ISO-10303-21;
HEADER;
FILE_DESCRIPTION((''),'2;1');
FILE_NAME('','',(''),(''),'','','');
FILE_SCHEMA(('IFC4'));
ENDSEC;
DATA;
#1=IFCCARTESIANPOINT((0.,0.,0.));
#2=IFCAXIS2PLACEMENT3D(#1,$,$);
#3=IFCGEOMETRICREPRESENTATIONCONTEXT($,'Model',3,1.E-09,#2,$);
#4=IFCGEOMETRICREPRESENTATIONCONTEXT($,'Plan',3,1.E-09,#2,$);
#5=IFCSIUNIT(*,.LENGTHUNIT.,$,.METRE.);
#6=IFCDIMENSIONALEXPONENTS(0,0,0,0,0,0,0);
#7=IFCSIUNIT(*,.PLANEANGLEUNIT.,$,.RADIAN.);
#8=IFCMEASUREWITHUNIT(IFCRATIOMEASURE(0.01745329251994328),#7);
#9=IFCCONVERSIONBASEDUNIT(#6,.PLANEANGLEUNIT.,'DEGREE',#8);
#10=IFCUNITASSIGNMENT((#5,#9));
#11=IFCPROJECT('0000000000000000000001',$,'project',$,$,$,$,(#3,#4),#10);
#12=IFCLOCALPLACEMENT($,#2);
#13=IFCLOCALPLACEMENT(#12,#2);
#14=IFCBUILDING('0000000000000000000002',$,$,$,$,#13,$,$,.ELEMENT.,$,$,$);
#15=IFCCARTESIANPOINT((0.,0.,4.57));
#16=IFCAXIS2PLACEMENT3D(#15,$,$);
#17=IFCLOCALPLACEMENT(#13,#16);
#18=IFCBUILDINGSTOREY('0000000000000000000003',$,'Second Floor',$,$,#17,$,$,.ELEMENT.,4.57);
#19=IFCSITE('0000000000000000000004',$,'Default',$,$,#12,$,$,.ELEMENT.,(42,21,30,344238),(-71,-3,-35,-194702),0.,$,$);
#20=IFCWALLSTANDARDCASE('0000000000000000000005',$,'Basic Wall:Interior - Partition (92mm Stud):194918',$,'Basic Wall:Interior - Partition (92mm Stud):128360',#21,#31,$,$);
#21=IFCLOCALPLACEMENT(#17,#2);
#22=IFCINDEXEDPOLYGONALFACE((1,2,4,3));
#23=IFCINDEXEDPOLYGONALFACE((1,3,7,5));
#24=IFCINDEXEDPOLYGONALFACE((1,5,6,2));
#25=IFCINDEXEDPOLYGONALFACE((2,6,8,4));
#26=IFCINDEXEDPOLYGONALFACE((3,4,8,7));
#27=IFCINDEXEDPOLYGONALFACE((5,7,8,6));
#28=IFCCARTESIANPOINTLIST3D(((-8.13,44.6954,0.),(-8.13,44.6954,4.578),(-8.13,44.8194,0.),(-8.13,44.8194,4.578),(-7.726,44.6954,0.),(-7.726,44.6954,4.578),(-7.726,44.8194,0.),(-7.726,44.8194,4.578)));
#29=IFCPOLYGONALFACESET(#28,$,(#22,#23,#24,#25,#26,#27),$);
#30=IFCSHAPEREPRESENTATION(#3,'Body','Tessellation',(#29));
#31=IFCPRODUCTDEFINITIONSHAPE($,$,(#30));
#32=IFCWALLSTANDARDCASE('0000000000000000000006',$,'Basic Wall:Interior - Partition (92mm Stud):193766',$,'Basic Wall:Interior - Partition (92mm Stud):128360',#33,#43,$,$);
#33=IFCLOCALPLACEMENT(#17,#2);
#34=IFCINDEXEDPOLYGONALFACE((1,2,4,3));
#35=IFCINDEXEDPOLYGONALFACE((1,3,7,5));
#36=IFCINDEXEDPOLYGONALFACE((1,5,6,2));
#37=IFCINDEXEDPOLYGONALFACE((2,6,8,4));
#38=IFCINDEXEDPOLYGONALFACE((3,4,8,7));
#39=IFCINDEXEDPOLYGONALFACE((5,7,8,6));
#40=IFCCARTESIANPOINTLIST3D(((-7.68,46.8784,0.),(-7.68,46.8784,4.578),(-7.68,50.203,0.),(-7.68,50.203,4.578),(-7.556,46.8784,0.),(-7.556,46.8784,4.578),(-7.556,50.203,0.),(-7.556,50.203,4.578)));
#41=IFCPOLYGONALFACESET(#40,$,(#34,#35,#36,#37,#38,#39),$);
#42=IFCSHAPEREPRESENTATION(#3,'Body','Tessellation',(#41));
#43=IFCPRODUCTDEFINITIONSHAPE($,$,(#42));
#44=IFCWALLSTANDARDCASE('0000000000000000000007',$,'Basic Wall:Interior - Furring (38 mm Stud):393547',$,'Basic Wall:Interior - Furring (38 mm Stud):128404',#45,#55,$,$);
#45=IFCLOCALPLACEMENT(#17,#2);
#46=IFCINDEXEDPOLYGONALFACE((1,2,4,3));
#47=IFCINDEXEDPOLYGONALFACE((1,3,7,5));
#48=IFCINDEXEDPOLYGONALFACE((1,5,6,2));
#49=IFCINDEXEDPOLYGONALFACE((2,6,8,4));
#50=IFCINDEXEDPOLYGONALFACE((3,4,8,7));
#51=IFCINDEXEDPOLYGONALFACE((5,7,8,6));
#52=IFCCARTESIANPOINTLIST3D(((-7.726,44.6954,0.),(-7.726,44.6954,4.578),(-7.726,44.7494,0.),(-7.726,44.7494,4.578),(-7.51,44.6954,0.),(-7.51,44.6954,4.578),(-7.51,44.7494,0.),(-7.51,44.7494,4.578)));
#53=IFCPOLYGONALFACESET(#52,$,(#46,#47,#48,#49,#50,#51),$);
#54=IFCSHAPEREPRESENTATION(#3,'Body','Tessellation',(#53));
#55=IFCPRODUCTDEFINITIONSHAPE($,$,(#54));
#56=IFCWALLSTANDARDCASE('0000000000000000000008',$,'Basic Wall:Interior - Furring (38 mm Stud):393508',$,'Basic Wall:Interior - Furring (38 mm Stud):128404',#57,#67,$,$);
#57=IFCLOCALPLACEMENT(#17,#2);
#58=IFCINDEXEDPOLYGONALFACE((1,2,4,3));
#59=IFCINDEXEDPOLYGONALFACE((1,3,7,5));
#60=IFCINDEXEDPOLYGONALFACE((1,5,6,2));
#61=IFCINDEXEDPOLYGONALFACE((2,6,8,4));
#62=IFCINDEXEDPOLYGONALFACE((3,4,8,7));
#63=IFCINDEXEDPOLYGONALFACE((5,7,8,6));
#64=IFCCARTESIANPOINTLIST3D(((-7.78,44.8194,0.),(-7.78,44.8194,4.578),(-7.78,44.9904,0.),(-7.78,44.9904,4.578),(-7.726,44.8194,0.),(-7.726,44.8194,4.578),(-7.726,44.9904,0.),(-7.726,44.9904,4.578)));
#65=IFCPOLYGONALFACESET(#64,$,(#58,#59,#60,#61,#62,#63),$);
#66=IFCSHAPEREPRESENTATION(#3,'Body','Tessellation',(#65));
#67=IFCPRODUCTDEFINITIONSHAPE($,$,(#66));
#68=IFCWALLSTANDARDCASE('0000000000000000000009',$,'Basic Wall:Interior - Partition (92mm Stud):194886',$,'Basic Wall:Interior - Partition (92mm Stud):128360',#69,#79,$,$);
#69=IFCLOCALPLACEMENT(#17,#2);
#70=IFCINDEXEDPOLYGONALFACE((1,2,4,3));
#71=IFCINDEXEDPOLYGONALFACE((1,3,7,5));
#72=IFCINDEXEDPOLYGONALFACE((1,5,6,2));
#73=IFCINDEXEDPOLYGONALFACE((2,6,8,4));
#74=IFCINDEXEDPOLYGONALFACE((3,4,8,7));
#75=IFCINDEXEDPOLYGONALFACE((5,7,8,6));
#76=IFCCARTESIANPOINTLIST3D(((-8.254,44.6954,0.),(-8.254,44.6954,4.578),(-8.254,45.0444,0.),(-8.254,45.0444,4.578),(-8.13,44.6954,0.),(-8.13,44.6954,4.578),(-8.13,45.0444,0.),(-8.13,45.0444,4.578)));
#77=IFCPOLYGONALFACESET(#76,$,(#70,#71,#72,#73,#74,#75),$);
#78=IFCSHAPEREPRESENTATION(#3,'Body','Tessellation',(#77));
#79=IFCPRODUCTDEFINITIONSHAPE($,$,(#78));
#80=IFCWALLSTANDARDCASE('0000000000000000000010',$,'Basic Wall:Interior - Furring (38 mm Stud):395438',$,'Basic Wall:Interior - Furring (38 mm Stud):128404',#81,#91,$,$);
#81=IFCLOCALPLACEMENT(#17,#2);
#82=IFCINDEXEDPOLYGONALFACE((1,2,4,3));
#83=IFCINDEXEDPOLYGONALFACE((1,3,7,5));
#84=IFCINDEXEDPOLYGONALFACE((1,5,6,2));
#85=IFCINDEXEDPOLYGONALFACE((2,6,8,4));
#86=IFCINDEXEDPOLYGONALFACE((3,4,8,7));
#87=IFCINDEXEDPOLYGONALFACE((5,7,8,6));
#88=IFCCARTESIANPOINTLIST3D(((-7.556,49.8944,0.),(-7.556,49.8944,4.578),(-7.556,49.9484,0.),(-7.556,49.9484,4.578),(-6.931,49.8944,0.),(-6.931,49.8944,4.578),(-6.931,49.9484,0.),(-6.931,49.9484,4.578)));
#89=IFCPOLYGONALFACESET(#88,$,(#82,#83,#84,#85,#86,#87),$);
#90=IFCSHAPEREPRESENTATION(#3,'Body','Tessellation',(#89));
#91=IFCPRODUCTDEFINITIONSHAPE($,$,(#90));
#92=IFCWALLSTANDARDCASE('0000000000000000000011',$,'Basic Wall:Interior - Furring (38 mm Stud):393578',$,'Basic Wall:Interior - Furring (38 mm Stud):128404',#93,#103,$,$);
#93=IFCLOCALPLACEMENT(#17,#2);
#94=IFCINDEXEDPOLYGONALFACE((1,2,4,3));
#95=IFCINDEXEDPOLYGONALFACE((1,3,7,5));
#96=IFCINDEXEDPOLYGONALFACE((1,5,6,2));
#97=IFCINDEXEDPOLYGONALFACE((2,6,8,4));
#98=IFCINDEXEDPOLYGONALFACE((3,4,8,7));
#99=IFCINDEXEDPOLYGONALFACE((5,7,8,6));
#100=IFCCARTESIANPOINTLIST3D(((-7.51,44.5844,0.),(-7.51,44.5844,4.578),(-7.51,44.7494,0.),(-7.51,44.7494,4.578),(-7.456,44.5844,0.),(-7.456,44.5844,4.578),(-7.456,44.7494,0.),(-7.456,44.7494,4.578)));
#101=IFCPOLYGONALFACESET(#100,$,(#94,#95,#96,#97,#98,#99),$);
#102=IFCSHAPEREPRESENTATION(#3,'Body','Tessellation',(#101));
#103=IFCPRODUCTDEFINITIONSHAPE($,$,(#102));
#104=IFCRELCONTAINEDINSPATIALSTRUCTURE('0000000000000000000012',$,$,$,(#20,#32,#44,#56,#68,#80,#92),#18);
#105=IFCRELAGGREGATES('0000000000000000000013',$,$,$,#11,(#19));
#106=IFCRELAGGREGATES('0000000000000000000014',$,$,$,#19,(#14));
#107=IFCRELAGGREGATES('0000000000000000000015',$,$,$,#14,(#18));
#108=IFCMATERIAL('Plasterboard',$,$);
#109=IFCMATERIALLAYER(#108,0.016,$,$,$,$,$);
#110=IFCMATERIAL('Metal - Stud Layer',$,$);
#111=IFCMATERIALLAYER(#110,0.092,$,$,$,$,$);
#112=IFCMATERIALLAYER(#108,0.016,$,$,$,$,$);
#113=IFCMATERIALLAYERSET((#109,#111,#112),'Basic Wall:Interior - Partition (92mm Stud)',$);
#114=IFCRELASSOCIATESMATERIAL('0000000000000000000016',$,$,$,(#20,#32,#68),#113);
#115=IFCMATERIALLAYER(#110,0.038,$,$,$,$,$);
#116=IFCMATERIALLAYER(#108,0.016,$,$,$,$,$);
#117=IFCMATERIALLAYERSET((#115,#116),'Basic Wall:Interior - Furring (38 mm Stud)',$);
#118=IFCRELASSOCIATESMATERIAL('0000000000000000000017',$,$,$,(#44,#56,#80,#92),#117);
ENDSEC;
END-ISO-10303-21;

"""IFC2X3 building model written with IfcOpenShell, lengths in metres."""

from ifc_helpers import new_model, entity, si_unit, converted_unit, frame, frame_2d, origin, place, context, project, spatial, rectangle, extrude, material, layer, layer_set, layer_usage, element, save


model = new_model("IFC2X3")

# Units and contexts
model_context = context("Model", 3, precision=1e-09, world=origin())
plan_context = context("Plan", 3, precision=1e-09, world=origin())
ifc_project = project(units=[si_unit("LENGTHUNIT", "METRE"), converted_unit("PLANEANGLEUNIT", "DEGREE", entity("IfcRatioMeasure", 0.01745329251994328), si_unit("PLANEANGLEUNIT", "RADIAN"), dimensions=[0, 0, 0, 0, 0, 0, 0])], contexts=[model_context, plan_context])

# Site, building, storey
site_placement = place(None, origin())
site = spatial("IfcSite", under=ifc_project, at=site_placement, Name="Default", CompositionType="ELEMENT", RefLatitude=(42, 21, 30, 344238), RefLongitude=(-71, -3, -35, -194702), RefElevation=0.0)
building_placement = place(site_placement, origin())
building = spatial("IfcBuilding", under=site, at=building_placement, CompositionType="ELEMENT")
storey_placement = place(building_placement, frame((0.0, 0.0, 4.57)))
storey = spatial("IfcBuildingStorey", under=building, at=storey_placement, Name="Second Floor", CompositionType="ELEMENT", Elevation=4.57)

# Walls
ifc_material_1 = material(Name="Plasterboard")
ifc_layer_1 = layer(ifc_material_1, 0.016)
ifc_material_2 = material(Name="Metal - Stud Layer")
ifc_layer_2 = layer(ifc_material_2, 0.092)
ifc_layer_3 = layer(ifc_material_1, 0.016)
ifc_layer_set_1 = layer_set([ifc_layer_1, ifc_layer_2, ifc_layer_3], Name="Basic Wall:Interior - Partition (92mm Stud)")
ifc_layer_usage_1 = layer_usage(ifc_layer_set_1, "AXIS2", "NEGATIVE", 0.062)
wall_1_placement = place(storey_placement, frame((-8.13, 44.7574, 0.0)))
element("IfcWallStandardCase", 1, at=wall_1_placement, inside=storey, material=ifc_layer_usage_1, Name="Basic Wall:Interior - Partition (92mm Stud):194918", ObjectType="Basic Wall:Interior - Partition (92mm Stud):128360", context=model_context, shape_type="SweptSolid", body=[
    extrude(rectangle(XDim=0.404, YDim=0.124, at=frame_2d((0.202, 0.0), x_axis=(-1.0, 0.0))), origin(), (0.0, 0.0, 1.0), 4.578),
])
wall_2_placement = place(storey_placement, frame((-7.618, 46.8784, 0.0), z_axis=(0.0, 0.0, 1.0), x_axis=(0.0, 1.0, 0.0)))
element("IfcWallStandardCase", 2, at=wall_2_placement, inside=storey, material=ifc_layer_usage_1, Name="Basic Wall:Interior - Partition (92mm Stud):193766", ObjectType="Basic Wall:Interior - Partition (92mm Stud):128360", context=model_context, shape_type="SweptSolid", body=[
    extrude(rectangle(XDim=3.3246, YDim=0.124, at=frame_2d((1.6623, 0.0), x_axis=(-1.0, 0.0))), origin(), (0.0, 0.0, 1.0), 4.578),
])
ifc_layer_4 = layer(ifc_material_2, 0.038)
ifc_layer_5 = layer(ifc_material_1, 0.016)
ifc_layer_set_2 = layer_set([ifc_layer_4, ifc_layer_5], Name="Basic Wall:Interior - Furring (38 mm Stud)")
ifc_layer_usage_2 = layer_usage(ifc_layer_set_2, "AXIS2", "NEGATIVE", 0.027)
wall_3_placement = place(storey_placement, frame((-7.726, 44.7224, 0.0)))
element("IfcWallStandardCase", 3, at=wall_3_placement, inside=storey, material=ifc_layer_usage_2, Name="Basic Wall:Interior - Furring (38 mm Stud):393547", ObjectType="Basic Wall:Interior - Furring (38 mm Stud):128404", context=model_context, shape_type="SweptSolid", body=[
    extrude(rectangle(XDim=0.216, YDim=0.054, at=frame_2d((0.108, 0.0), x_axis=(-1.0, 0.0))), origin(), (0.0, 0.0, 1.0), 4.578),
])
wall_4_placement = place(storey_placement, frame((-7.753, 44.9904, 0.0), z_axis=(0.0, 0.0, 1.0), x_axis=(0.0, -1.0, 0.0)))
element("IfcWallStandardCase", 4, at=wall_4_placement, inside=storey, material=ifc_layer_usage_2, Name="Basic Wall:Interior - Furring (38 mm Stud):393508", ObjectType="Basic Wall:Interior - Furring (38 mm Stud):128404", context=model_context, shape_type="SweptSolid", body=[
    extrude(rectangle(XDim=0.171, YDim=0.054, at=frame_2d((0.0855, 0.0), x_axis=(-1.0, 0.0))), origin(), (0.0, 0.0, 1.0), 4.578),
])
wall_5_placement = place(storey_placement, frame((-8.192, 45.0444, 0.0), z_axis=(0.0, 0.0, 1.0), x_axis=(0.0, -1.0, 0.0)))
element("IfcWallStandardCase", 5, at=wall_5_placement, inside=storey, material=ifc_layer_usage_1, Name="Basic Wall:Interior - Partition (92mm Stud):194886", ObjectType="Basic Wall:Interior - Partition (92mm Stud):128360", context=model_context, shape_type="SweptSolid", body=[
    extrude(rectangle(XDim=0.349, YDim=0.124, at=frame_2d((0.1745, 0.0), x_axis=(-1.0, 0.0))), origin(), (0.0, 0.0, 1.0), 4.578),
])
wall_6_placement = place(storey_placement, frame((-7.556, 49.9214, 0.0)))
element("IfcWallStandardCase", 6, at=wall_6_placement, inside=storey, material=ifc_layer_usage_2, Name="Basic Wall:Interior - Furring (38 mm Stud):395438", ObjectType="Basic Wall:Interior - Furring (38 mm Stud):128404", context=model_context, shape_type="SweptSolid", body=[
    extrude(rectangle(XDim=0.625, YDim=0.054, at=frame_2d((0.3125, 0.0), x_axis=(-1.0, 0.0))), origin(), (0.0, 0.0, 1.0), 4.578),
])
wall_7_placement = place(storey_placement, frame((-7.483, 44.7494, 0.0), z_axis=(0.0, 0.0, 1.0), x_axis=(0.0, -1.0, 0.0)))
element("IfcWallStandardCase", 7, at=wall_7_placement, inside=storey, material=ifc_layer_usage_2, Name="Basic Wall:Interior - Furring (38 mm Stud):393578", ObjectType="Basic Wall:Interior - Furring (38 mm Stud):128404", context=model_context, shape_type="SweptSolid", body=[
    extrude(rectangle(XDim=0.165, YDim=0.054, at=frame_2d((0.0825, 0.0), x_axis=(-1.0, 0.0))), origin(), (0.0, 0.0, 1.0), 4.578),
])

save(model, "model.ifc")
